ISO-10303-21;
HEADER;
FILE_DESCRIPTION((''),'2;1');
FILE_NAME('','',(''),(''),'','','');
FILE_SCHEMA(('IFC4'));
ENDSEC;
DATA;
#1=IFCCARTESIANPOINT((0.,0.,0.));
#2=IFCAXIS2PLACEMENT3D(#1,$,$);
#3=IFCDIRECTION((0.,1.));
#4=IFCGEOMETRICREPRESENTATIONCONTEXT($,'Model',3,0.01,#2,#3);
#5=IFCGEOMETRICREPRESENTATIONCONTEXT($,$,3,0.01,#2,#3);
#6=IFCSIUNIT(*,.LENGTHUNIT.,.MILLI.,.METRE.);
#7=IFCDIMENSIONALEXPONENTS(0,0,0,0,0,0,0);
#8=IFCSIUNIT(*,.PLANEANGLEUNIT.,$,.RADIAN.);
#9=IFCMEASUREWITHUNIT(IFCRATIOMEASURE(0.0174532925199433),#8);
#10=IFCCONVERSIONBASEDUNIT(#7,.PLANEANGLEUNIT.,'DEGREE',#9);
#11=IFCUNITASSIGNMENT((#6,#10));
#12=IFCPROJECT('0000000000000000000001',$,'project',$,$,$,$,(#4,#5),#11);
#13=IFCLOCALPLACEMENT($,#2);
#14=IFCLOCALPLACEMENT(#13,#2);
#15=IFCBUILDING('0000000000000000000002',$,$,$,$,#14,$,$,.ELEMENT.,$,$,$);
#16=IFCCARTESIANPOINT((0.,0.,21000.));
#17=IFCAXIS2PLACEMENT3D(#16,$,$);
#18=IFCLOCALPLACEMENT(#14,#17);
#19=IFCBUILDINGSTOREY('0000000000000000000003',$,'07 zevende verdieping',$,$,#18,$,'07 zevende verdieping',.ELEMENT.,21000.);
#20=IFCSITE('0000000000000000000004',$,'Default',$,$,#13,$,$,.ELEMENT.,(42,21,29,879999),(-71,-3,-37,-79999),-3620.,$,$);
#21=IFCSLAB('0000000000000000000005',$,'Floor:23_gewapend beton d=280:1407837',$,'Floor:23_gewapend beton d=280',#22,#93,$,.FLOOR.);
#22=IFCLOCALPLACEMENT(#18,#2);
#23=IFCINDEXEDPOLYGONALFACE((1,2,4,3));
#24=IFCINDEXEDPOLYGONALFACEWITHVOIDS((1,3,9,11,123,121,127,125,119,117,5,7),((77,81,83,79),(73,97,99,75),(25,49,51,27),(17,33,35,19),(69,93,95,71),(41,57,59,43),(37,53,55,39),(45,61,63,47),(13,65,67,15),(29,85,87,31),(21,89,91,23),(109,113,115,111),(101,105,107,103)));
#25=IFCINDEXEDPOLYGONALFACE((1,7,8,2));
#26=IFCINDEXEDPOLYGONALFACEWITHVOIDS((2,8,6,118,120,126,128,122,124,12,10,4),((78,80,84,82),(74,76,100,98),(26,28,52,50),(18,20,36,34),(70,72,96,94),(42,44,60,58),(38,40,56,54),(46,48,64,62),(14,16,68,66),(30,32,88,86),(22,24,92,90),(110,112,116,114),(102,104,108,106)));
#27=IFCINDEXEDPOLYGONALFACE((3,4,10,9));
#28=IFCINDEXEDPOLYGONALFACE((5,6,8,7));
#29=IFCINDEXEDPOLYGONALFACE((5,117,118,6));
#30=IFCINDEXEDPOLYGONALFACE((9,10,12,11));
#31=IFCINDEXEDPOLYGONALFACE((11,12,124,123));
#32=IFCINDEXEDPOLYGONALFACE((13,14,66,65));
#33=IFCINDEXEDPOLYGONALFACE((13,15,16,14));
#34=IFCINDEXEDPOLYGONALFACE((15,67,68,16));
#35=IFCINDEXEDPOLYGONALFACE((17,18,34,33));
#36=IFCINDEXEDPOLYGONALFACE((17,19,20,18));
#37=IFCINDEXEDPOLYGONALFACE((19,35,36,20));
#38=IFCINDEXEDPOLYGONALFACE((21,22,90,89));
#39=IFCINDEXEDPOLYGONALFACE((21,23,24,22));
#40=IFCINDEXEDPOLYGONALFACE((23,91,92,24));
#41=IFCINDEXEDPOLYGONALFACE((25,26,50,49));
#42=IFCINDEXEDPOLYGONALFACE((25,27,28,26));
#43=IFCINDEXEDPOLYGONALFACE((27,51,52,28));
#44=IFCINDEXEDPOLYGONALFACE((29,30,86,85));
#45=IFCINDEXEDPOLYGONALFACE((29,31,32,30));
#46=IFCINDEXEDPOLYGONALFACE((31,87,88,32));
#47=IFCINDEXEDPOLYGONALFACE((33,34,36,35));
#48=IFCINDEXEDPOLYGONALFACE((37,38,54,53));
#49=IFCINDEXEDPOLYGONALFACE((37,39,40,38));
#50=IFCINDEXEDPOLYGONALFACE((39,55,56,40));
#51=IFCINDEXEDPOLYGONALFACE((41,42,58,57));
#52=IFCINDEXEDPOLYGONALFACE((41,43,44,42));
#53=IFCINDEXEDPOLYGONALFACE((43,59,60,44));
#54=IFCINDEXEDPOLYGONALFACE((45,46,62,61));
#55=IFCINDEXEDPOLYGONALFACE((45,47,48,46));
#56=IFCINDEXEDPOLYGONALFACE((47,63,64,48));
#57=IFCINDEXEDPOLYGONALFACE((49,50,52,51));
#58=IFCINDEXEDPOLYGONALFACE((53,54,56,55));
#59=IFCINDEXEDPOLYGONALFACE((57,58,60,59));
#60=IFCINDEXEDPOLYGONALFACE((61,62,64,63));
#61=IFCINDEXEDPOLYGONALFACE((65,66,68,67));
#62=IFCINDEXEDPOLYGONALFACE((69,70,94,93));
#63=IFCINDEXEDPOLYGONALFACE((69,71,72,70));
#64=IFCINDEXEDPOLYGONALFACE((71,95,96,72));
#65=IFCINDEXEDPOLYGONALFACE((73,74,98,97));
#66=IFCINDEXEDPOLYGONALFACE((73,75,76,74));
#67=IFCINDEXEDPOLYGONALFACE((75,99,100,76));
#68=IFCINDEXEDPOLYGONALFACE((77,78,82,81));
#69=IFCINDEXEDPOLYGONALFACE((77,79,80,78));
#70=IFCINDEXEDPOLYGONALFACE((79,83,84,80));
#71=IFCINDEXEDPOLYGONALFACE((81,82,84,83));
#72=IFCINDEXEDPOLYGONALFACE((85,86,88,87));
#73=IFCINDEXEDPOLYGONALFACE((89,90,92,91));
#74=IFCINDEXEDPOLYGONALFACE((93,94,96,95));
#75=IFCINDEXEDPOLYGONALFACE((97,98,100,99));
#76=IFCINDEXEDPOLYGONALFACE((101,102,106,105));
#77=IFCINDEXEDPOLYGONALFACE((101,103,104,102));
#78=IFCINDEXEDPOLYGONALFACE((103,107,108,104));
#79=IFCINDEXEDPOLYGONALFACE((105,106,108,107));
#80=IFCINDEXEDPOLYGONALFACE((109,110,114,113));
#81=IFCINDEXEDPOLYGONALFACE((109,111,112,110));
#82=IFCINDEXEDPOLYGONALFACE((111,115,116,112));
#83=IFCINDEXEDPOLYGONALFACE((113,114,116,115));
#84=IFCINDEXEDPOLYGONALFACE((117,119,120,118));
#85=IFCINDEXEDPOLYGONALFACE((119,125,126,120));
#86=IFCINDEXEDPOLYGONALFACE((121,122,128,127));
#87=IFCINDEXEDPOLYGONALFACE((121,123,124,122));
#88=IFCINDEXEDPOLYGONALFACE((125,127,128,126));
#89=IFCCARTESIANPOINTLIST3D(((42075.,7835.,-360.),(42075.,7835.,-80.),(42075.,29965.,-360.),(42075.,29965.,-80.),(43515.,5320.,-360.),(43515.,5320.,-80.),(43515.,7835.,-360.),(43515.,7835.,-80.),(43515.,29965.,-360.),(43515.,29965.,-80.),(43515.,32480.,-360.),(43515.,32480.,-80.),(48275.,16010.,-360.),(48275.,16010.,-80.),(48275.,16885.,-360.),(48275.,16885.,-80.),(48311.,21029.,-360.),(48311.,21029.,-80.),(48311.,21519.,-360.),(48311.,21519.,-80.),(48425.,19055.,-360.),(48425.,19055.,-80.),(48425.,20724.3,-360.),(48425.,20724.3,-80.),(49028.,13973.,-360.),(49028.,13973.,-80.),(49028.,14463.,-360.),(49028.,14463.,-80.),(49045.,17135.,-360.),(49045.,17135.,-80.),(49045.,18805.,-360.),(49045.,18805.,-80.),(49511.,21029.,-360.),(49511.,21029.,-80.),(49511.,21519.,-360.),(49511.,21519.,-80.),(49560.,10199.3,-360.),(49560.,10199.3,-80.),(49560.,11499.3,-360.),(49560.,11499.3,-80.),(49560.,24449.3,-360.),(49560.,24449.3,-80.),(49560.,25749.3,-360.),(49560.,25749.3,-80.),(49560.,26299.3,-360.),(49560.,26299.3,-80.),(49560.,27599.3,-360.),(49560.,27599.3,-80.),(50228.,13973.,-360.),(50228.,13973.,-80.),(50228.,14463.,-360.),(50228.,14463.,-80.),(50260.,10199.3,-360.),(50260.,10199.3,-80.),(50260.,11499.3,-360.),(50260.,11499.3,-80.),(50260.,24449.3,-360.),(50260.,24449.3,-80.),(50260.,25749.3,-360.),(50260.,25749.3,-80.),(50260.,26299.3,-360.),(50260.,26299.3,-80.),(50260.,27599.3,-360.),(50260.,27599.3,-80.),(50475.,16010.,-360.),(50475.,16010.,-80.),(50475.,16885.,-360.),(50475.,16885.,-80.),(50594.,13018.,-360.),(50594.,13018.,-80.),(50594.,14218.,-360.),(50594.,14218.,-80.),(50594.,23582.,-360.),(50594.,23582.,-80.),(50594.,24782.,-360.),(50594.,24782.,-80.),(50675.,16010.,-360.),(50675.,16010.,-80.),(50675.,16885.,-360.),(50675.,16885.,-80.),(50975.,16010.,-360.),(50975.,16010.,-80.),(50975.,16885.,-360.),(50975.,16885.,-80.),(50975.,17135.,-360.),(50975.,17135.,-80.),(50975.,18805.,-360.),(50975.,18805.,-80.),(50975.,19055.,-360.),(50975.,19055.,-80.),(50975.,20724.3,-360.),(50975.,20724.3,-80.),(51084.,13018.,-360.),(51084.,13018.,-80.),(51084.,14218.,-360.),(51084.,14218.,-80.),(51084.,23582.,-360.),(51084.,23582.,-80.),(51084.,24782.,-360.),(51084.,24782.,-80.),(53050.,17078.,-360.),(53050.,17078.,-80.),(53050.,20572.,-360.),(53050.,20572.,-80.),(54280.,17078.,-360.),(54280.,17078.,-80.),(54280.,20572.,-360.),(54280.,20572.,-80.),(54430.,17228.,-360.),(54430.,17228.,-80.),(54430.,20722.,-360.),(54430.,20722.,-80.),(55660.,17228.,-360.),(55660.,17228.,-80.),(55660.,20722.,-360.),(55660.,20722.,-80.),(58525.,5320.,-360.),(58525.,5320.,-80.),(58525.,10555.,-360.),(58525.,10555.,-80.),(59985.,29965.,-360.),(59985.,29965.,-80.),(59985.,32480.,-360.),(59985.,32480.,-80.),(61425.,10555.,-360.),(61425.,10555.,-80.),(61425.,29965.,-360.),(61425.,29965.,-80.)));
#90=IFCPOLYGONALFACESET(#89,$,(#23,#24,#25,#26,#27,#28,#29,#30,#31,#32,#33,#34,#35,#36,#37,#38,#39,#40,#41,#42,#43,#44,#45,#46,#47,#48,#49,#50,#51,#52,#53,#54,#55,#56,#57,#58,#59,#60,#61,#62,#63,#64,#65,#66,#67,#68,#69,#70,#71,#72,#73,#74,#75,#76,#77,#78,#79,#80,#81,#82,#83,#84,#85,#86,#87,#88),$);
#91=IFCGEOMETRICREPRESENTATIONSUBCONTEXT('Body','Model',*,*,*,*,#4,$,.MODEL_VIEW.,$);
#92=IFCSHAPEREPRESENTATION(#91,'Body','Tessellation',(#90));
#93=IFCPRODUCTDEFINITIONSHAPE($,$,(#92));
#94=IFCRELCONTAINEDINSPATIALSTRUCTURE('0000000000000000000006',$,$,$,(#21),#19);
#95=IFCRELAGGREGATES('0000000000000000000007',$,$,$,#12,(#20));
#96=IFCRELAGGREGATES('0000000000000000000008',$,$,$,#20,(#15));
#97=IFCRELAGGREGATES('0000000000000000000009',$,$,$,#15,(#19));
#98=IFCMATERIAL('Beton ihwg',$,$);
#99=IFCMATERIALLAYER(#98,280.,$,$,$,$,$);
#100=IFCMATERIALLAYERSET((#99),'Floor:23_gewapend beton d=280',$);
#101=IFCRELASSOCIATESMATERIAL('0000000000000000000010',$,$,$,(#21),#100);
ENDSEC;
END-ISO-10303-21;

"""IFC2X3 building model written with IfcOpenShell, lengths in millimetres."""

from ifc_helpers import new_model, entity, si_unit, converted_unit, direction, frame, frame_2d, origin, place, context, subcontext, project, spatial, polyline, rectangle, outline, extrude, material, layer, layer_set, layer_usage, element, save


model = new_model("IFC2X3")

# Units and contexts
model_context = context("Model", 3, precision=0.01, world=origin(), true_north=direction((0.0, 1.0)))
context_of_model = context(None, 3, precision=0.01, world=origin(), true_north=direction((0.0, 1.0)))
body_context = subcontext(model_context, "Body", "Model", "MODEL_VIEW")
ifc_project = project(units=[si_unit("LENGTHUNIT", "METRE", prefix="MILLI"), converted_unit("PLANEANGLEUNIT", "DEGREE", entity("IfcRatioMeasure", 0.0174532925199433), si_unit("PLANEANGLEUNIT", "RADIAN"), dimensions=[0, 0, 0, 0, 0, 0, 0])], contexts=[model_context, context_of_model])

# Site, building, storey
site_placement = place(None, origin())
site = spatial("IfcSite", under=ifc_project, at=site_placement, Name="Default", CompositionType="ELEMENT", RefLatitude=(42, 21, 29, 879999), RefLongitude=(-71, -3, -37, -79999), RefElevation=-3620.0)
building_placement = place(site_placement, origin())
building = spatial("IfcBuilding", under=site, at=building_placement, CompositionType="ELEMENT")
storey_placement = place(building_placement, frame((0.0, 0.0, 21000.0)))
storey = spatial("IfcBuildingStorey", under=building, at=storey_placement, Name="07 zevende verdieping", LongName="07 zevende verdieping", CompositionType="ELEMENT", Elevation=21000.0)

# Slab, openings
ifc_material_1 = material(Name="Beton ihwg")
ifc_layer_1 = layer(ifc_material_1, 280.0)
ifc_layer_set_1 = layer_set([ifc_layer_1], Name="Floor:23_gewapend beton d=280")
ifc_layer_usage_1 = layer_usage(ifc_layer_set_1, "AXIS3", "POSITIVE", 0.0)
slab_1_placement = place(storey_placement, frame((42075.0, 5320.0, -360.0)))
slab_1 = element("IfcSlab", 1, at=slab_1_placement, inside=storey, material=ifc_layer_usage_1, Name="Floor:23_gewapend beton d=280:1407837", ObjectType="Floor:23_gewapend beton d=280", PredefinedType="FLOOR", context=body_context, shape_type="SweptSolid", body=[
    extrude(outline(polyline([(8235.0, 13580.0), (-8235.0, 13580.0), (-8235.0, 11065.0), (-9675.0, 11065.0), (-9675.0, -8345.0), (-6775.0, -8345.0), (-6775.0, -13580.0), (8235.0, -13580.0), (8235.0, -11065.0), (9675.0, -11065.0), (9675.0, 11065.0), (8235.0, 11065.0), (8235.0, 13580.0)])), frame((9675.0, 13580.0, 280.0), z_axis=(0.0, 0.0, -1.0), x_axis=(-1.0, 0.0, 0.0)), (0.0, 0.0, 1.0), 280.0),
])
opening_1_placement = place(storey_placement, frame((42075.0, 5320.0, -360.0)))
element("IfcOpeningElement", 2, at=opening_1_placement, cuts=slab_1, ObjectType="Opening", context=body_context, shape_type="SweptSolid", body=[
    extrude(rectangle(XDim=1669.3, YDim=2550.0, at=frame_2d((2050.0, 989.6), x_axis=(0.0, 1.0))), frame((9675.0, 13580.0, 280.0), z_axis=(0.0, 0.0, -1.0), x_axis=(-1.0, 0.0, 0.0)), (0.0, 0.0, 1.0), 280.0),
])
opening_2_placement = place(storey_placement, frame((42075.0, 5320.0, -360.0)))
element("IfcOpeningElement", 3, at=opening_2_placement, cuts=slab_1, ObjectType="Opening", context=body_context, shape_type="SweptSolid", body=[
    extrude(rectangle(XDim=1670.0, YDim=1930.0, at=frame_2d((1740.0, -930.0), x_axis=(0.0, 1.0))), frame((9675.0, 13580.0, 280.0), z_axis=(0.0, 0.0, -1.0), x_axis=(-1.0, 0.0, 0.0)), (0.0, 0.0, 1.0), 280.0),
])
opening_3_placement = place(storey_placement, frame((42075.0, 5320.0, -360.0)))
element("IfcOpeningElement", 4, at=opening_3_placement, cuts=slab_1, ObjectType="Opening", context=body_context, shape_type="SweptSolid", body=[
    extrude(rectangle(XDim=1300.0, YDim=700.0, at=frame_2d((1840.0, 8049.3), x_axis=(0.0, 1.0))), frame((9675.0, 13580.0, 280.0), z_axis=(0.0, 0.0, -1.0), x_axis=(-1.0, 0.0, 0.0)), (0.0, 0.0, 1.0), 280.0),
])
opening_4_placement = place(storey_placement, frame((42075.0, 5320.0, -360.0)))
element("IfcOpeningElement", 5, at=opening_4_placement, cuts=slab_1, ObjectType="Opening", context=body_context, shape_type="SweptSolid", body=[
    extrude(rectangle(XDim=1300.0, YDim=700.0, at=frame_2d((1840.0, 6199.3), x_axis=(0.0, 1.0))), frame((9675.0, 13580.0, 280.0), z_axis=(0.0, 0.0, -1.0), x_axis=(-1.0, 0.0, 0.0)), (0.0, 0.0, 1.0), 280.0),
])
opening_5_placement = place(storey_placement, frame((42075.0, 5320.0, -360.0)))
element("IfcOpeningElement", 6, at=opening_5_placement, cuts=slab_1, ObjectType="Opening", context=body_context, shape_type="SweptSolid", body=[
    extrude(rectangle(XDim=1300.0, YDim=700.0, at=frame_2d((1840.0, -8050.7), x_axis=(0.0, 1.0))), frame((9675.0, 13580.0, 280.0), z_axis=(0.0, 0.0, -1.0), x_axis=(-1.0, 0.0, 0.0)), (0.0, 0.0, 1.0), 280.0),
])
opening_6_placement = place(storey_placement, frame((42075.0, 5320.0, -360.0)))
element("IfcOpeningElement", 7, at=opening_6_placement, cuts=slab_1, ObjectType="Opening", context=body_context, shape_type="SweptSolid", body=[
    extrude(rectangle(XDim=875.0, YDim=2200.0, at=frame_2d((2375.0, -2452.5), x_axis=(0.0, 1.0))), frame((9675.0, 13580.0, 280.0), z_axis=(0.0, 0.0, -1.0), x_axis=(-1.0, 0.0, 0.0)), (0.0, 0.0, 1.0), 280.0),
])
opening_7_placement = place(storey_placement, frame((42075.0, 5320.0, -360.0)))
element("IfcOpeningElement", 8, at=opening_7_placement, cuts=slab_1, ObjectType="Opening", context=body_context, shape_type="SweptSolid", body=[
    extrude(rectangle(XDim=875.0, YDim=300.0, at=frame_2d((925.0, -2452.5), x_axis=(0.0, 1.0))), frame((9675.0, 13580.0, 280.0), z_axis=(0.0, 0.0, -1.0), x_axis=(-1.0, 0.0, 0.0)), (0.0, 0.0, 1.0), 280.0),
])
opening_8_placement = place(storey_placement, frame((42075.0, 5320.0, -360.0)))
element("IfcOpeningElement", 9, at=opening_8_placement, cuts=slab_1, ObjectType="Opening", context=body_context, shape_type="SweptSolid", body=[
    extrude(rectangle(XDim=3494.0, YDim=1230.0, at=frame_2d((-3295.0, 75.0), x_axis=(0.0, 1.0))), frame((9675.0, 13580.0, 280.0), z_axis=(0.0, 0.0, -1.0), x_axis=(-1.0, 0.0, 0.0)), (0.0, 0.0, 1.0), 280.0),
])
opening_9_placement = place(storey_placement, frame((42075.0, 5320.0, -360.0)))
element("IfcOpeningElement", 10, at=opening_9_placement, cuts=slab_1, ObjectType="Opening", context=body_context, shape_type="SweptSolid", body=[
    extrude(rectangle(XDim=3494.0, YDim=1230.0, at=frame_2d((-1915.0, -75.0), x_axis=(0.0, 1.0))), frame((9675.0, 13580.0, 280.0), z_axis=(0.0, 0.0, -1.0), x_axis=(-1.0, 0.0, 0.0)), (0.0, 0.0, 1.0), 280.0),
])
opening_10_placement = place(storey_placement, frame((42075.0, 5320.0, -360.0)))
element("IfcOpeningElement", 11, at=opening_10_placement, cuts=slab_1, ObjectType="Opening", context=body_context, shape_type="SweptSolid", body=[
    extrude(rectangle(XDim=490.0, YDim=1200.0, at=frame_2d((911.0, 5282.0), x_axis=(-1.0, 0.0))), frame((9675.0, 13580.0, 280.0), z_axis=(0.0, 0.0, -1.0), x_axis=(-1.0, 0.0, 0.0)), (0.0, 0.0, 1.0), 280.0),
])
opening_11_placement = place(storey_placement, frame((42075.0, 5320.0, -360.0)))
element("IfcOpeningElement", 12, at=opening_11_placement, cuts=slab_1, ObjectType="Opening", context=body_context, shape_type="SweptSolid", body=[
    extrude(rectangle(XDim=490.0, YDim=1200.0, at=frame_2d((2839.0, 2374.0), x_axis=(0.0, 1.0))), frame((9675.0, 13580.0, 280.0), z_axis=(0.0, 0.0, -1.0), x_axis=(-1.0, 0.0, 0.0)), (0.0, 0.0, 1.0), 280.0),
])
opening_12_placement = place(storey_placement, frame((42075.0, 5320.0, -360.0)))
element("IfcOpeningElement", 13, at=opening_12_placement, cuts=slab_1, ObjectType="Opening", context=body_context, shape_type="SweptSolid", body=[
    extrude(rectangle(XDim=490.0, YDim=1200.0, at=frame_2d((911.0, -5282.0), x_axis=(-1.0, 0.0))), frame((9675.0, 13580.0, 280.0), z_axis=(0.0, 0.0, -1.0), x_axis=(-1.0, 0.0, 0.0)), (0.0, 0.0, 1.0), 280.0),
])
opening_13_placement = place(storey_placement, frame((42075.0, 5320.0, -360.0)))
element("IfcOpeningElement", 14, at=opening_13_placement, cuts=slab_1, ObjectType="Opening", context=body_context, shape_type="SweptSolid", body=[
    extrude(rectangle(XDim=490.0, YDim=1200.0, at=frame_2d((2122.0, -4682.0), x_axis=(0.0, 1.0))), frame((9675.0, 13580.0, 280.0), z_axis=(0.0, 0.0, -1.0), x_axis=(-1.0, 0.0, 0.0)), (0.0, 0.0, 1.0), 280.0),
])

save(model, "model.ifc")
